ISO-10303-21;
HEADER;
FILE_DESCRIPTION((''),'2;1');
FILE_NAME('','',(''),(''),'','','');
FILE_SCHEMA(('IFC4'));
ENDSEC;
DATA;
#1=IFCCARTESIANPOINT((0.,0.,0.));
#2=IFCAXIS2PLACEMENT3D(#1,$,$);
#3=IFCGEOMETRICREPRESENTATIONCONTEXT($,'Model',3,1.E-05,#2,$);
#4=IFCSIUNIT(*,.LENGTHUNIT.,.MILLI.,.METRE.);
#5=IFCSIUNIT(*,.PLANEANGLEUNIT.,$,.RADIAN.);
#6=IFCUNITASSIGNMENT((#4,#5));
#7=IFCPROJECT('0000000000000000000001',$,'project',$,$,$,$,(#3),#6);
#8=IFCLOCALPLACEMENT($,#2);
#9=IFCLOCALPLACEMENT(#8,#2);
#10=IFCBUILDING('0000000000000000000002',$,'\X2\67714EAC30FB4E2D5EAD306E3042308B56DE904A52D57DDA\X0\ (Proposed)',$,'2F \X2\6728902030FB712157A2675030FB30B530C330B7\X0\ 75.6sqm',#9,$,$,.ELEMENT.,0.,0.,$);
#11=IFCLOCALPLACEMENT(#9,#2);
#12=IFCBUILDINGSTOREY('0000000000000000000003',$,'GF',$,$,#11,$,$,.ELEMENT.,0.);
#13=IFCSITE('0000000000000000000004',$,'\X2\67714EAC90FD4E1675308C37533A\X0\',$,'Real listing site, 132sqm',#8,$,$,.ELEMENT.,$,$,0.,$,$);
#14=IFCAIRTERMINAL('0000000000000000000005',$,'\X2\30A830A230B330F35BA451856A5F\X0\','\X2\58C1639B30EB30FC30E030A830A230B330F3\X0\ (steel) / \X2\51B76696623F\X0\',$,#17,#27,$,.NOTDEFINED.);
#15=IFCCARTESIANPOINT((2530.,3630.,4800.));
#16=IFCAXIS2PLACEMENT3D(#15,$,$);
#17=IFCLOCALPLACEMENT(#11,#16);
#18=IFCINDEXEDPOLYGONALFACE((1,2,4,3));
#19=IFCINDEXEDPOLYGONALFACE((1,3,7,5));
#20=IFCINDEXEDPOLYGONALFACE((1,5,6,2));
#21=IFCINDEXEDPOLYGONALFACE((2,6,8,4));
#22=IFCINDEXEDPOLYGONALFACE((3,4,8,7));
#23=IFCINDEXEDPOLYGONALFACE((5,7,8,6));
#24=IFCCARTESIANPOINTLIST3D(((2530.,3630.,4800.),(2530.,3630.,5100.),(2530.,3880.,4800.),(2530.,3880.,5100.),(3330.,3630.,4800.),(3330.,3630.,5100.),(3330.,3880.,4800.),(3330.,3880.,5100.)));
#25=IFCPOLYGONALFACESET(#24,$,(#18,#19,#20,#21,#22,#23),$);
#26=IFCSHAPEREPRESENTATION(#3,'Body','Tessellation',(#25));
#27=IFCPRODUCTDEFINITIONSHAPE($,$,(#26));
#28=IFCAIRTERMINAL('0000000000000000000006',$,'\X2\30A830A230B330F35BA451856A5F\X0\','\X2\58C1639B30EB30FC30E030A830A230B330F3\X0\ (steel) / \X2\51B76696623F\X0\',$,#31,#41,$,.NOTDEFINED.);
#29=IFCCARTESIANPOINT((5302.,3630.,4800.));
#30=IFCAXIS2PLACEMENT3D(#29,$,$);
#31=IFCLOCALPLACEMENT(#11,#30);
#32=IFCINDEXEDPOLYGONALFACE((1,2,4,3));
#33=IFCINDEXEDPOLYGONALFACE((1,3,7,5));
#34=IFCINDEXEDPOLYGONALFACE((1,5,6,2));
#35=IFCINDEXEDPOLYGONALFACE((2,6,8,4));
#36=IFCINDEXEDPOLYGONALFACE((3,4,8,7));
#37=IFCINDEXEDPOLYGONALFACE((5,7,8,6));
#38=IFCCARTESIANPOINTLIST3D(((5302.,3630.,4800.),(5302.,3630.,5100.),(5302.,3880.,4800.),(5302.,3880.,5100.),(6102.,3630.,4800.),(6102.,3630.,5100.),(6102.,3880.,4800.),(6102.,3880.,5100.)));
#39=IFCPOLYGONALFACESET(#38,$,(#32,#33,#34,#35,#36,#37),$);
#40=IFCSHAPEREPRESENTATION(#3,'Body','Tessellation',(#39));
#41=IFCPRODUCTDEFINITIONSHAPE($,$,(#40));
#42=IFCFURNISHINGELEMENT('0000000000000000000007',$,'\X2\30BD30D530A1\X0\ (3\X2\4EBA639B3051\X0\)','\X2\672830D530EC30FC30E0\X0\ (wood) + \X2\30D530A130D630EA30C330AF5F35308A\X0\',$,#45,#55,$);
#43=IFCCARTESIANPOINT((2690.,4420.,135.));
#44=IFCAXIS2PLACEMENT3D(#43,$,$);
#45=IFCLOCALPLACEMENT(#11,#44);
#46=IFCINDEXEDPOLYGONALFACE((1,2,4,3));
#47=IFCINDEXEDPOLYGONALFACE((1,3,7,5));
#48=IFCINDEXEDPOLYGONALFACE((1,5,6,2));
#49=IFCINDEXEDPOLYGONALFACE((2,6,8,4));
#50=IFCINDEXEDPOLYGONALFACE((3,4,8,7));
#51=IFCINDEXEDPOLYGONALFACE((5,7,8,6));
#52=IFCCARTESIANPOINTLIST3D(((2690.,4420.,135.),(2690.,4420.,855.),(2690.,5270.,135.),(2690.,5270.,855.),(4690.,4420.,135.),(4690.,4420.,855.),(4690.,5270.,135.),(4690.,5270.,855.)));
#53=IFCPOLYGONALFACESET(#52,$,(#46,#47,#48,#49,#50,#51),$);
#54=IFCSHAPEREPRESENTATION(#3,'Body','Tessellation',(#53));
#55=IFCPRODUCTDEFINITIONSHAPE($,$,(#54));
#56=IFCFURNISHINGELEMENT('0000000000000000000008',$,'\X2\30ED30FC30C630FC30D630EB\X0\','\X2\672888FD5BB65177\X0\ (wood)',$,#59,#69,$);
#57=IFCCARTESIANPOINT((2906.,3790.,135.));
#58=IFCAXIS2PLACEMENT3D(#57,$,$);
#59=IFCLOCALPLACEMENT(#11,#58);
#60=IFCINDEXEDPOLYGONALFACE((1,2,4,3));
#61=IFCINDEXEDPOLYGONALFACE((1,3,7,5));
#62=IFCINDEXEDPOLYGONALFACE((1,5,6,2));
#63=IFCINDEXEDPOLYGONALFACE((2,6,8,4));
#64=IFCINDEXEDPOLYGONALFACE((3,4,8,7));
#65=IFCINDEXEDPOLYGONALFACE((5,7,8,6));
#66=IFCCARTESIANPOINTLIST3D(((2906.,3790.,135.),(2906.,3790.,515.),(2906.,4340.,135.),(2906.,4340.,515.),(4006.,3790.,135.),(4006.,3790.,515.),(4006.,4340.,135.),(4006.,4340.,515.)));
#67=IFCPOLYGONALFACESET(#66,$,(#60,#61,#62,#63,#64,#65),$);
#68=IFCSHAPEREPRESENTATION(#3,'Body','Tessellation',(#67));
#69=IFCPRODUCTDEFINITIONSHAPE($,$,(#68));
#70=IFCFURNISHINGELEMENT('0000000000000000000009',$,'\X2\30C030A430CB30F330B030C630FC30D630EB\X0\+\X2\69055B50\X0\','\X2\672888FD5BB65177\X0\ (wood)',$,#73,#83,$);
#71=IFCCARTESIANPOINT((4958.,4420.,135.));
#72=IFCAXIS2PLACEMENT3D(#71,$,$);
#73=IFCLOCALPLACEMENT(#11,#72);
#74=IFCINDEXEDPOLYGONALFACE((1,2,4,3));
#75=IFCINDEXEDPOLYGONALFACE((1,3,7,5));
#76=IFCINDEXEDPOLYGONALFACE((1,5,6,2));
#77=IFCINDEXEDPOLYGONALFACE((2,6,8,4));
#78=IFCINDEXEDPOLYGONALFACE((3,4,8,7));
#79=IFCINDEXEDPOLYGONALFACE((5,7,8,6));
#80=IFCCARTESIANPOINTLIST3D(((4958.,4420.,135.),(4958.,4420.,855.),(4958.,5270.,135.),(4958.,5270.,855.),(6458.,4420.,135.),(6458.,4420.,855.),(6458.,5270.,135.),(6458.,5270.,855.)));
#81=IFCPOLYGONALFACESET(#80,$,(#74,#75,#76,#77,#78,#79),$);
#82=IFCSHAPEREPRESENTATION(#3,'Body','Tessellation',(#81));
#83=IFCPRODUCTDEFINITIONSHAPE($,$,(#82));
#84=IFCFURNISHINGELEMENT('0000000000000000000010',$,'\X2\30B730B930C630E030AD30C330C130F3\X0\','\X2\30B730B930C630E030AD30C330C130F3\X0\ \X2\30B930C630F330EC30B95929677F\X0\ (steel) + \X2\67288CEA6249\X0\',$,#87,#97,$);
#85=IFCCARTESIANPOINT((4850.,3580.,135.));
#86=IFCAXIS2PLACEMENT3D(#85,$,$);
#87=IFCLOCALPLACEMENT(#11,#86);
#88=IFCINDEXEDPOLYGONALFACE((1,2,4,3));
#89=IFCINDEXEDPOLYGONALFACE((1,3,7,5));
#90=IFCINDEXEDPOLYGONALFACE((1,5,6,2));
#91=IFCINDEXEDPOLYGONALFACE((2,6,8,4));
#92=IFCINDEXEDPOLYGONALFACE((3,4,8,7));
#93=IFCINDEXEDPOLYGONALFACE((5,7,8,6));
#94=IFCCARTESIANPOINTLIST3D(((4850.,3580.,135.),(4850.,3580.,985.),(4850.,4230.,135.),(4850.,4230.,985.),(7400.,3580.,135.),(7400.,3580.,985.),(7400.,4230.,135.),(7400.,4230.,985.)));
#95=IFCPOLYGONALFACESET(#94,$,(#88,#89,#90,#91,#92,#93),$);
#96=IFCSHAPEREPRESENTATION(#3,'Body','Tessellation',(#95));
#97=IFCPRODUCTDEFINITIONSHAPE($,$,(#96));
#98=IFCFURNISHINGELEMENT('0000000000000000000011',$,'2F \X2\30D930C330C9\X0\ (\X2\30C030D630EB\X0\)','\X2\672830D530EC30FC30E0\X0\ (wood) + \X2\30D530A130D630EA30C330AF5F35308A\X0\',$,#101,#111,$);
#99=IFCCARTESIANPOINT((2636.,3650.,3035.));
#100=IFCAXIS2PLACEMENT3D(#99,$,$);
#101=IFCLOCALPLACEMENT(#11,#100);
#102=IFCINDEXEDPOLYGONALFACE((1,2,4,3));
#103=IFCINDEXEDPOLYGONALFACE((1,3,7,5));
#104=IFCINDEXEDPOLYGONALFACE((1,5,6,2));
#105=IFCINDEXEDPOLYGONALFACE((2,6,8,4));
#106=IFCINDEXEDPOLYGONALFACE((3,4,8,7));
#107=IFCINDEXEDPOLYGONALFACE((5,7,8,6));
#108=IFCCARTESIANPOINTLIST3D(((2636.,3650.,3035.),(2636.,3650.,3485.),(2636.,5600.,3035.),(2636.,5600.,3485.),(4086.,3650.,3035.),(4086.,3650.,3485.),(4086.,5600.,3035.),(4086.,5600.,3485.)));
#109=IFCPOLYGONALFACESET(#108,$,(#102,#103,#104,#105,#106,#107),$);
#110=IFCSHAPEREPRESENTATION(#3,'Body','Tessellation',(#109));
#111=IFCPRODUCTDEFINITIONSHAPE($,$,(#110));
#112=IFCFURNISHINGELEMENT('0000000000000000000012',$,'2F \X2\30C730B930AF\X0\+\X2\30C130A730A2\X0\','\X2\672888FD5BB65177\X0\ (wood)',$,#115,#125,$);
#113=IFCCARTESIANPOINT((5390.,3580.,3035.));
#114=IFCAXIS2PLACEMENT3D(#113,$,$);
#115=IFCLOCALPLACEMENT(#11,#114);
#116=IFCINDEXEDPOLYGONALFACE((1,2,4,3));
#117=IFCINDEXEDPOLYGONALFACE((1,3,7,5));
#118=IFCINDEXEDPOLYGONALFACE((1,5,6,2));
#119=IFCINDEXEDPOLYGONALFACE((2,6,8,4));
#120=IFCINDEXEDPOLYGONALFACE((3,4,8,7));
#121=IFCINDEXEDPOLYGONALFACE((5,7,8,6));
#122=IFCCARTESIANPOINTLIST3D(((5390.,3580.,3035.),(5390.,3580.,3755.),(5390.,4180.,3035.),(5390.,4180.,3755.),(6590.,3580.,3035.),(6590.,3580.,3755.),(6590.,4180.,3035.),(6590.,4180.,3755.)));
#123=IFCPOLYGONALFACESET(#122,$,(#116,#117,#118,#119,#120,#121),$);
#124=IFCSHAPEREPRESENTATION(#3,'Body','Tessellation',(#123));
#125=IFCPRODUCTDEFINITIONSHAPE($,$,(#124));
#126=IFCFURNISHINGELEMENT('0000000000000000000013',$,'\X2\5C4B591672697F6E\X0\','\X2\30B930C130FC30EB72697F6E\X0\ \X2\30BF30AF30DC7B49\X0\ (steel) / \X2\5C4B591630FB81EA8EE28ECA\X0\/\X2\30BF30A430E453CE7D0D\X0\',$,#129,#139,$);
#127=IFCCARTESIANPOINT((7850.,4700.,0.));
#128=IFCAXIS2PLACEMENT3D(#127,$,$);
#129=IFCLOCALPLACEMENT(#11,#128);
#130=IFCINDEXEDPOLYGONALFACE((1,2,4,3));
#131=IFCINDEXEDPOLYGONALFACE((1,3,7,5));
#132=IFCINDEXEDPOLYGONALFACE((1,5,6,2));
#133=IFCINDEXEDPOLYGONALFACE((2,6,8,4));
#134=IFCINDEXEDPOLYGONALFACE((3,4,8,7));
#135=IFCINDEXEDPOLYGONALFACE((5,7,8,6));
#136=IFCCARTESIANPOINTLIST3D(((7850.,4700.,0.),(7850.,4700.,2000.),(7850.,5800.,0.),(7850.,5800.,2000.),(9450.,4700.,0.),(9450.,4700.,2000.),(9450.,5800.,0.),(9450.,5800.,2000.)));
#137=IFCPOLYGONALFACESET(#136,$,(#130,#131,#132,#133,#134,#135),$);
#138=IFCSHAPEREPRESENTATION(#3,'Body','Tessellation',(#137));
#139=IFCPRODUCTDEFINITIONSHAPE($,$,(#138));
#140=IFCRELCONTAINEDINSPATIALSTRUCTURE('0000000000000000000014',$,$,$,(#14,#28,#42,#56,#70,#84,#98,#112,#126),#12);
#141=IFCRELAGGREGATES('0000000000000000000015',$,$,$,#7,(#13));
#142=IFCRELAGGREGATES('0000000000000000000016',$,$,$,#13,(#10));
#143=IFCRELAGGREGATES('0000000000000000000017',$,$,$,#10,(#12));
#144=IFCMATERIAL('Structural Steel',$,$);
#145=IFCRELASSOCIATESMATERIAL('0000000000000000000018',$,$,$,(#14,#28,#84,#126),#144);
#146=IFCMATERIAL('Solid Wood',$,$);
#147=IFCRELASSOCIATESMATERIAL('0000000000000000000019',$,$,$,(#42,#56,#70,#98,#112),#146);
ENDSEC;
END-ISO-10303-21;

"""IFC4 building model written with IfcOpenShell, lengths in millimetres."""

from ifc_helpers import new_model, si_unit, frame, frame_2d, origin, place, context, project, spatial, rectangle, extrude, material, element, save


model = new_model("IFC4")

# Units and contexts
model_context = context("Model", 3, precision=1e-05, world=origin())
ifc_project = project(units=[si_unit("LENGTHUNIT", "METRE", prefix="MILLI"), si_unit("PLANEANGLEUNIT", "RADIAN")], contexts=[model_context])

# Site, building, storey
site_placement = place(None, origin())
site = spatial("IfcSite", under=ifc_project, at=site_placement, Name="東京都世田谷区", ObjectType="Real listing site, 132sqm", CompositionType="ELEMENT", RefElevation=0.0)
building_placement = place(site_placement, origin())
building = spatial("IfcBuilding", under=site, at=building_placement, Name="東京・中庭のある回遊動線 (Proposed)", ObjectType="2F 木造・無垢材・サッシ 75.6sqm", CompositionType="ELEMENT", ElevationOfRefHeight=0.0, ElevationOfTerrain=0.0)
storey_placement = place(building_placement, origin())
storey = spatial("IfcBuildingStorey", under=building, at=storey_placement, Name="GF", CompositionType="ELEMENT", Elevation=0.0)

# Shared definitions
ifc_material_1 = material(Name="Solid Wood")

# Shared definitions
ifc_material_2 = material(Name="Structural Steel")

# Air terminals
air_terminal_1_placement = place(storey_placement, frame((2530.0, 3630.0, 4800.0)))
element("IfcAirTerminal", 1, at=air_terminal_1_placement, inside=storey, material=ifc_material_2, Name="エアコン室内機", Description="壁掛ルームエアコン (steel) / 冷暖房", PredefinedType="NOTDEFINED", context=model_context, shape_type="SweptSolid", body=[
    extrude(rectangle(XDim=800.0, YDim=250.0, at=frame_2d((400.0, 125.0))), frame((2530.0, 3630.0, 4800.0)), (0.0, 0.0, 1.0), 300.0),
])
air_terminal_2_placement = place(storey_placement, frame((5302.0, 3630.0, 4800.0)))
element("IfcAirTerminal", 2, at=air_terminal_2_placement, inside=storey, material=ifc_material_2, Name="エアコン室内機", Description="壁掛ルームエアコン (steel) / 冷暖房", PredefinedType="NOTDEFINED", context=model_context, shape_type="SweptSolid", body=[
    extrude(rectangle(XDim=800.0, YDim=250.0, at=frame_2d((400.0, 125.0))), frame((5302.0, 3630.0, 4800.0)), (0.0, 0.0, 1.0), 300.0),
])

# Furnishing elements
furnishing_1_placement = place(storey_placement, frame((2690.0, 4420.0, 135.0)))
element("IfcFurnishingElement", 3, at=furnishing_1_placement, inside=storey, material=ifc_material_1, Name="ソファ (3人掛け)", Description="木フレーム (wood) + ファブリック張り", context=model_context, shape_type="SweptSolid", body=[
    extrude(rectangle(XDim=2000.0, YDim=850.0, at=frame_2d((1000.0, 425.0))), frame((2690.0, 4420.0, 135.0)), (0.0, 0.0, 1.0), 720.0),
])
furnishing_2_placement = place(storey_placement, frame((2906.0, 3790.0, 135.0)))
element("IfcFurnishingElement", 4, at=furnishing_2_placement, inside=storey, material=ifc_material_1, Name="ローテーブル", Description="木製家具 (wood)", context=model_context, shape_type="SweptSolid", body=[
    extrude(rectangle(XDim=1100.0, YDim=550.0, at=frame_2d((550.0, 275.0))), frame((2906.0, 3790.0, 135.0)), (0.0, 0.0, 1.0), 380.0),
])
furnishing_3_placement = place(storey_placement, frame((4958.0, 4420.0, 135.0)))
element("IfcFurnishingElement", 5, at=furnishing_3_placement, inside=storey, material=ifc_material_1, Name="ダイニングテーブル+椅子", Description="木製家具 (wood)", context=model_context, shape_type="SweptSolid", body=[
    extrude(rectangle(XDim=1500.0, YDim=850.0, at=frame_2d((750.0, 425.0))), frame((4958.0, 4420.0, 135.0)), (0.0, 0.0, 1.0), 720.0),
])
furnishing_4_placement = place(storey_placement, frame((4850.0, 3580.0, 135.0)))
element("IfcFurnishingElement", 6, at=furnishing_4_placement, inside=storey, material=ifc_material_2, Name="システムキッチン", Description="システムキッチン ステンレス天板 (steel) + 木質扉", context=model_context, shape_type="SweptSolid", body=[
    extrude(rectangle(XDim=2550.0, YDim=650.0, at=frame_2d((1275.0, 325.0))), frame((4850.0, 3580.0, 135.0)), (0.0, 0.0, 1.0), 850.0),
])
furnishing_5_placement = place(storey_placement, frame((2636.0, 3650.0, 3035.0)))
element("IfcFurnishingElement", 7, at=furnishing_5_placement, inside=storey, material=ifc_material_1, Name="2F ベッド (ダブル)", Description="木フレーム (wood) + ファブリック張り", context=model_context, shape_type="SweptSolid", body=[
    extrude(rectangle(XDim=1450.0, YDim=1950.0, at=frame_2d((725.0, 975.0))), frame((2636.0, 3650.0, 3035.0)), (0.0, 0.0, 1.0), 450.0),
])
furnishing_6_placement = place(storey_placement, frame((5390.0, 3580.0, 3035.0)))
element("IfcFurnishingElement", 8, at=furnishing_6_placement, inside=storey, material=ifc_material_1, Name="2F デスク+チェア", Description="木製家具 (wood)", context=model_context, shape_type="SweptSolid", body=[
    extrude(rectangle(XDim=1200.0, YDim=600.0, at=frame_2d((600.0, 300.0))), frame((5390.0, 3580.0, 3035.0)), (0.0, 0.0, 1.0), 720.0),
])
furnishing_7_placement = place(storey_placement, frame((7850.0, 4700.0, 0.0)))
element("IfcFurnishingElement", 9, at=furnishing_7_placement, inside=storey, material=ifc_material_2, Name="屋外物置", Description="スチール物置 タクボ等 (steel) / 屋外・自転車/タイヤ収納", context=model_context, shape_type="SweptSolid", body=[
    extrude(rectangle(XDim=1600.0, YDim=1100.0, at=frame_2d((800.0, 550.0))), frame((7850.0, 4700.0, 0.0)), (0.0, 0.0, 1.0), 2000.0),
])

save(model, "model.ifc")
